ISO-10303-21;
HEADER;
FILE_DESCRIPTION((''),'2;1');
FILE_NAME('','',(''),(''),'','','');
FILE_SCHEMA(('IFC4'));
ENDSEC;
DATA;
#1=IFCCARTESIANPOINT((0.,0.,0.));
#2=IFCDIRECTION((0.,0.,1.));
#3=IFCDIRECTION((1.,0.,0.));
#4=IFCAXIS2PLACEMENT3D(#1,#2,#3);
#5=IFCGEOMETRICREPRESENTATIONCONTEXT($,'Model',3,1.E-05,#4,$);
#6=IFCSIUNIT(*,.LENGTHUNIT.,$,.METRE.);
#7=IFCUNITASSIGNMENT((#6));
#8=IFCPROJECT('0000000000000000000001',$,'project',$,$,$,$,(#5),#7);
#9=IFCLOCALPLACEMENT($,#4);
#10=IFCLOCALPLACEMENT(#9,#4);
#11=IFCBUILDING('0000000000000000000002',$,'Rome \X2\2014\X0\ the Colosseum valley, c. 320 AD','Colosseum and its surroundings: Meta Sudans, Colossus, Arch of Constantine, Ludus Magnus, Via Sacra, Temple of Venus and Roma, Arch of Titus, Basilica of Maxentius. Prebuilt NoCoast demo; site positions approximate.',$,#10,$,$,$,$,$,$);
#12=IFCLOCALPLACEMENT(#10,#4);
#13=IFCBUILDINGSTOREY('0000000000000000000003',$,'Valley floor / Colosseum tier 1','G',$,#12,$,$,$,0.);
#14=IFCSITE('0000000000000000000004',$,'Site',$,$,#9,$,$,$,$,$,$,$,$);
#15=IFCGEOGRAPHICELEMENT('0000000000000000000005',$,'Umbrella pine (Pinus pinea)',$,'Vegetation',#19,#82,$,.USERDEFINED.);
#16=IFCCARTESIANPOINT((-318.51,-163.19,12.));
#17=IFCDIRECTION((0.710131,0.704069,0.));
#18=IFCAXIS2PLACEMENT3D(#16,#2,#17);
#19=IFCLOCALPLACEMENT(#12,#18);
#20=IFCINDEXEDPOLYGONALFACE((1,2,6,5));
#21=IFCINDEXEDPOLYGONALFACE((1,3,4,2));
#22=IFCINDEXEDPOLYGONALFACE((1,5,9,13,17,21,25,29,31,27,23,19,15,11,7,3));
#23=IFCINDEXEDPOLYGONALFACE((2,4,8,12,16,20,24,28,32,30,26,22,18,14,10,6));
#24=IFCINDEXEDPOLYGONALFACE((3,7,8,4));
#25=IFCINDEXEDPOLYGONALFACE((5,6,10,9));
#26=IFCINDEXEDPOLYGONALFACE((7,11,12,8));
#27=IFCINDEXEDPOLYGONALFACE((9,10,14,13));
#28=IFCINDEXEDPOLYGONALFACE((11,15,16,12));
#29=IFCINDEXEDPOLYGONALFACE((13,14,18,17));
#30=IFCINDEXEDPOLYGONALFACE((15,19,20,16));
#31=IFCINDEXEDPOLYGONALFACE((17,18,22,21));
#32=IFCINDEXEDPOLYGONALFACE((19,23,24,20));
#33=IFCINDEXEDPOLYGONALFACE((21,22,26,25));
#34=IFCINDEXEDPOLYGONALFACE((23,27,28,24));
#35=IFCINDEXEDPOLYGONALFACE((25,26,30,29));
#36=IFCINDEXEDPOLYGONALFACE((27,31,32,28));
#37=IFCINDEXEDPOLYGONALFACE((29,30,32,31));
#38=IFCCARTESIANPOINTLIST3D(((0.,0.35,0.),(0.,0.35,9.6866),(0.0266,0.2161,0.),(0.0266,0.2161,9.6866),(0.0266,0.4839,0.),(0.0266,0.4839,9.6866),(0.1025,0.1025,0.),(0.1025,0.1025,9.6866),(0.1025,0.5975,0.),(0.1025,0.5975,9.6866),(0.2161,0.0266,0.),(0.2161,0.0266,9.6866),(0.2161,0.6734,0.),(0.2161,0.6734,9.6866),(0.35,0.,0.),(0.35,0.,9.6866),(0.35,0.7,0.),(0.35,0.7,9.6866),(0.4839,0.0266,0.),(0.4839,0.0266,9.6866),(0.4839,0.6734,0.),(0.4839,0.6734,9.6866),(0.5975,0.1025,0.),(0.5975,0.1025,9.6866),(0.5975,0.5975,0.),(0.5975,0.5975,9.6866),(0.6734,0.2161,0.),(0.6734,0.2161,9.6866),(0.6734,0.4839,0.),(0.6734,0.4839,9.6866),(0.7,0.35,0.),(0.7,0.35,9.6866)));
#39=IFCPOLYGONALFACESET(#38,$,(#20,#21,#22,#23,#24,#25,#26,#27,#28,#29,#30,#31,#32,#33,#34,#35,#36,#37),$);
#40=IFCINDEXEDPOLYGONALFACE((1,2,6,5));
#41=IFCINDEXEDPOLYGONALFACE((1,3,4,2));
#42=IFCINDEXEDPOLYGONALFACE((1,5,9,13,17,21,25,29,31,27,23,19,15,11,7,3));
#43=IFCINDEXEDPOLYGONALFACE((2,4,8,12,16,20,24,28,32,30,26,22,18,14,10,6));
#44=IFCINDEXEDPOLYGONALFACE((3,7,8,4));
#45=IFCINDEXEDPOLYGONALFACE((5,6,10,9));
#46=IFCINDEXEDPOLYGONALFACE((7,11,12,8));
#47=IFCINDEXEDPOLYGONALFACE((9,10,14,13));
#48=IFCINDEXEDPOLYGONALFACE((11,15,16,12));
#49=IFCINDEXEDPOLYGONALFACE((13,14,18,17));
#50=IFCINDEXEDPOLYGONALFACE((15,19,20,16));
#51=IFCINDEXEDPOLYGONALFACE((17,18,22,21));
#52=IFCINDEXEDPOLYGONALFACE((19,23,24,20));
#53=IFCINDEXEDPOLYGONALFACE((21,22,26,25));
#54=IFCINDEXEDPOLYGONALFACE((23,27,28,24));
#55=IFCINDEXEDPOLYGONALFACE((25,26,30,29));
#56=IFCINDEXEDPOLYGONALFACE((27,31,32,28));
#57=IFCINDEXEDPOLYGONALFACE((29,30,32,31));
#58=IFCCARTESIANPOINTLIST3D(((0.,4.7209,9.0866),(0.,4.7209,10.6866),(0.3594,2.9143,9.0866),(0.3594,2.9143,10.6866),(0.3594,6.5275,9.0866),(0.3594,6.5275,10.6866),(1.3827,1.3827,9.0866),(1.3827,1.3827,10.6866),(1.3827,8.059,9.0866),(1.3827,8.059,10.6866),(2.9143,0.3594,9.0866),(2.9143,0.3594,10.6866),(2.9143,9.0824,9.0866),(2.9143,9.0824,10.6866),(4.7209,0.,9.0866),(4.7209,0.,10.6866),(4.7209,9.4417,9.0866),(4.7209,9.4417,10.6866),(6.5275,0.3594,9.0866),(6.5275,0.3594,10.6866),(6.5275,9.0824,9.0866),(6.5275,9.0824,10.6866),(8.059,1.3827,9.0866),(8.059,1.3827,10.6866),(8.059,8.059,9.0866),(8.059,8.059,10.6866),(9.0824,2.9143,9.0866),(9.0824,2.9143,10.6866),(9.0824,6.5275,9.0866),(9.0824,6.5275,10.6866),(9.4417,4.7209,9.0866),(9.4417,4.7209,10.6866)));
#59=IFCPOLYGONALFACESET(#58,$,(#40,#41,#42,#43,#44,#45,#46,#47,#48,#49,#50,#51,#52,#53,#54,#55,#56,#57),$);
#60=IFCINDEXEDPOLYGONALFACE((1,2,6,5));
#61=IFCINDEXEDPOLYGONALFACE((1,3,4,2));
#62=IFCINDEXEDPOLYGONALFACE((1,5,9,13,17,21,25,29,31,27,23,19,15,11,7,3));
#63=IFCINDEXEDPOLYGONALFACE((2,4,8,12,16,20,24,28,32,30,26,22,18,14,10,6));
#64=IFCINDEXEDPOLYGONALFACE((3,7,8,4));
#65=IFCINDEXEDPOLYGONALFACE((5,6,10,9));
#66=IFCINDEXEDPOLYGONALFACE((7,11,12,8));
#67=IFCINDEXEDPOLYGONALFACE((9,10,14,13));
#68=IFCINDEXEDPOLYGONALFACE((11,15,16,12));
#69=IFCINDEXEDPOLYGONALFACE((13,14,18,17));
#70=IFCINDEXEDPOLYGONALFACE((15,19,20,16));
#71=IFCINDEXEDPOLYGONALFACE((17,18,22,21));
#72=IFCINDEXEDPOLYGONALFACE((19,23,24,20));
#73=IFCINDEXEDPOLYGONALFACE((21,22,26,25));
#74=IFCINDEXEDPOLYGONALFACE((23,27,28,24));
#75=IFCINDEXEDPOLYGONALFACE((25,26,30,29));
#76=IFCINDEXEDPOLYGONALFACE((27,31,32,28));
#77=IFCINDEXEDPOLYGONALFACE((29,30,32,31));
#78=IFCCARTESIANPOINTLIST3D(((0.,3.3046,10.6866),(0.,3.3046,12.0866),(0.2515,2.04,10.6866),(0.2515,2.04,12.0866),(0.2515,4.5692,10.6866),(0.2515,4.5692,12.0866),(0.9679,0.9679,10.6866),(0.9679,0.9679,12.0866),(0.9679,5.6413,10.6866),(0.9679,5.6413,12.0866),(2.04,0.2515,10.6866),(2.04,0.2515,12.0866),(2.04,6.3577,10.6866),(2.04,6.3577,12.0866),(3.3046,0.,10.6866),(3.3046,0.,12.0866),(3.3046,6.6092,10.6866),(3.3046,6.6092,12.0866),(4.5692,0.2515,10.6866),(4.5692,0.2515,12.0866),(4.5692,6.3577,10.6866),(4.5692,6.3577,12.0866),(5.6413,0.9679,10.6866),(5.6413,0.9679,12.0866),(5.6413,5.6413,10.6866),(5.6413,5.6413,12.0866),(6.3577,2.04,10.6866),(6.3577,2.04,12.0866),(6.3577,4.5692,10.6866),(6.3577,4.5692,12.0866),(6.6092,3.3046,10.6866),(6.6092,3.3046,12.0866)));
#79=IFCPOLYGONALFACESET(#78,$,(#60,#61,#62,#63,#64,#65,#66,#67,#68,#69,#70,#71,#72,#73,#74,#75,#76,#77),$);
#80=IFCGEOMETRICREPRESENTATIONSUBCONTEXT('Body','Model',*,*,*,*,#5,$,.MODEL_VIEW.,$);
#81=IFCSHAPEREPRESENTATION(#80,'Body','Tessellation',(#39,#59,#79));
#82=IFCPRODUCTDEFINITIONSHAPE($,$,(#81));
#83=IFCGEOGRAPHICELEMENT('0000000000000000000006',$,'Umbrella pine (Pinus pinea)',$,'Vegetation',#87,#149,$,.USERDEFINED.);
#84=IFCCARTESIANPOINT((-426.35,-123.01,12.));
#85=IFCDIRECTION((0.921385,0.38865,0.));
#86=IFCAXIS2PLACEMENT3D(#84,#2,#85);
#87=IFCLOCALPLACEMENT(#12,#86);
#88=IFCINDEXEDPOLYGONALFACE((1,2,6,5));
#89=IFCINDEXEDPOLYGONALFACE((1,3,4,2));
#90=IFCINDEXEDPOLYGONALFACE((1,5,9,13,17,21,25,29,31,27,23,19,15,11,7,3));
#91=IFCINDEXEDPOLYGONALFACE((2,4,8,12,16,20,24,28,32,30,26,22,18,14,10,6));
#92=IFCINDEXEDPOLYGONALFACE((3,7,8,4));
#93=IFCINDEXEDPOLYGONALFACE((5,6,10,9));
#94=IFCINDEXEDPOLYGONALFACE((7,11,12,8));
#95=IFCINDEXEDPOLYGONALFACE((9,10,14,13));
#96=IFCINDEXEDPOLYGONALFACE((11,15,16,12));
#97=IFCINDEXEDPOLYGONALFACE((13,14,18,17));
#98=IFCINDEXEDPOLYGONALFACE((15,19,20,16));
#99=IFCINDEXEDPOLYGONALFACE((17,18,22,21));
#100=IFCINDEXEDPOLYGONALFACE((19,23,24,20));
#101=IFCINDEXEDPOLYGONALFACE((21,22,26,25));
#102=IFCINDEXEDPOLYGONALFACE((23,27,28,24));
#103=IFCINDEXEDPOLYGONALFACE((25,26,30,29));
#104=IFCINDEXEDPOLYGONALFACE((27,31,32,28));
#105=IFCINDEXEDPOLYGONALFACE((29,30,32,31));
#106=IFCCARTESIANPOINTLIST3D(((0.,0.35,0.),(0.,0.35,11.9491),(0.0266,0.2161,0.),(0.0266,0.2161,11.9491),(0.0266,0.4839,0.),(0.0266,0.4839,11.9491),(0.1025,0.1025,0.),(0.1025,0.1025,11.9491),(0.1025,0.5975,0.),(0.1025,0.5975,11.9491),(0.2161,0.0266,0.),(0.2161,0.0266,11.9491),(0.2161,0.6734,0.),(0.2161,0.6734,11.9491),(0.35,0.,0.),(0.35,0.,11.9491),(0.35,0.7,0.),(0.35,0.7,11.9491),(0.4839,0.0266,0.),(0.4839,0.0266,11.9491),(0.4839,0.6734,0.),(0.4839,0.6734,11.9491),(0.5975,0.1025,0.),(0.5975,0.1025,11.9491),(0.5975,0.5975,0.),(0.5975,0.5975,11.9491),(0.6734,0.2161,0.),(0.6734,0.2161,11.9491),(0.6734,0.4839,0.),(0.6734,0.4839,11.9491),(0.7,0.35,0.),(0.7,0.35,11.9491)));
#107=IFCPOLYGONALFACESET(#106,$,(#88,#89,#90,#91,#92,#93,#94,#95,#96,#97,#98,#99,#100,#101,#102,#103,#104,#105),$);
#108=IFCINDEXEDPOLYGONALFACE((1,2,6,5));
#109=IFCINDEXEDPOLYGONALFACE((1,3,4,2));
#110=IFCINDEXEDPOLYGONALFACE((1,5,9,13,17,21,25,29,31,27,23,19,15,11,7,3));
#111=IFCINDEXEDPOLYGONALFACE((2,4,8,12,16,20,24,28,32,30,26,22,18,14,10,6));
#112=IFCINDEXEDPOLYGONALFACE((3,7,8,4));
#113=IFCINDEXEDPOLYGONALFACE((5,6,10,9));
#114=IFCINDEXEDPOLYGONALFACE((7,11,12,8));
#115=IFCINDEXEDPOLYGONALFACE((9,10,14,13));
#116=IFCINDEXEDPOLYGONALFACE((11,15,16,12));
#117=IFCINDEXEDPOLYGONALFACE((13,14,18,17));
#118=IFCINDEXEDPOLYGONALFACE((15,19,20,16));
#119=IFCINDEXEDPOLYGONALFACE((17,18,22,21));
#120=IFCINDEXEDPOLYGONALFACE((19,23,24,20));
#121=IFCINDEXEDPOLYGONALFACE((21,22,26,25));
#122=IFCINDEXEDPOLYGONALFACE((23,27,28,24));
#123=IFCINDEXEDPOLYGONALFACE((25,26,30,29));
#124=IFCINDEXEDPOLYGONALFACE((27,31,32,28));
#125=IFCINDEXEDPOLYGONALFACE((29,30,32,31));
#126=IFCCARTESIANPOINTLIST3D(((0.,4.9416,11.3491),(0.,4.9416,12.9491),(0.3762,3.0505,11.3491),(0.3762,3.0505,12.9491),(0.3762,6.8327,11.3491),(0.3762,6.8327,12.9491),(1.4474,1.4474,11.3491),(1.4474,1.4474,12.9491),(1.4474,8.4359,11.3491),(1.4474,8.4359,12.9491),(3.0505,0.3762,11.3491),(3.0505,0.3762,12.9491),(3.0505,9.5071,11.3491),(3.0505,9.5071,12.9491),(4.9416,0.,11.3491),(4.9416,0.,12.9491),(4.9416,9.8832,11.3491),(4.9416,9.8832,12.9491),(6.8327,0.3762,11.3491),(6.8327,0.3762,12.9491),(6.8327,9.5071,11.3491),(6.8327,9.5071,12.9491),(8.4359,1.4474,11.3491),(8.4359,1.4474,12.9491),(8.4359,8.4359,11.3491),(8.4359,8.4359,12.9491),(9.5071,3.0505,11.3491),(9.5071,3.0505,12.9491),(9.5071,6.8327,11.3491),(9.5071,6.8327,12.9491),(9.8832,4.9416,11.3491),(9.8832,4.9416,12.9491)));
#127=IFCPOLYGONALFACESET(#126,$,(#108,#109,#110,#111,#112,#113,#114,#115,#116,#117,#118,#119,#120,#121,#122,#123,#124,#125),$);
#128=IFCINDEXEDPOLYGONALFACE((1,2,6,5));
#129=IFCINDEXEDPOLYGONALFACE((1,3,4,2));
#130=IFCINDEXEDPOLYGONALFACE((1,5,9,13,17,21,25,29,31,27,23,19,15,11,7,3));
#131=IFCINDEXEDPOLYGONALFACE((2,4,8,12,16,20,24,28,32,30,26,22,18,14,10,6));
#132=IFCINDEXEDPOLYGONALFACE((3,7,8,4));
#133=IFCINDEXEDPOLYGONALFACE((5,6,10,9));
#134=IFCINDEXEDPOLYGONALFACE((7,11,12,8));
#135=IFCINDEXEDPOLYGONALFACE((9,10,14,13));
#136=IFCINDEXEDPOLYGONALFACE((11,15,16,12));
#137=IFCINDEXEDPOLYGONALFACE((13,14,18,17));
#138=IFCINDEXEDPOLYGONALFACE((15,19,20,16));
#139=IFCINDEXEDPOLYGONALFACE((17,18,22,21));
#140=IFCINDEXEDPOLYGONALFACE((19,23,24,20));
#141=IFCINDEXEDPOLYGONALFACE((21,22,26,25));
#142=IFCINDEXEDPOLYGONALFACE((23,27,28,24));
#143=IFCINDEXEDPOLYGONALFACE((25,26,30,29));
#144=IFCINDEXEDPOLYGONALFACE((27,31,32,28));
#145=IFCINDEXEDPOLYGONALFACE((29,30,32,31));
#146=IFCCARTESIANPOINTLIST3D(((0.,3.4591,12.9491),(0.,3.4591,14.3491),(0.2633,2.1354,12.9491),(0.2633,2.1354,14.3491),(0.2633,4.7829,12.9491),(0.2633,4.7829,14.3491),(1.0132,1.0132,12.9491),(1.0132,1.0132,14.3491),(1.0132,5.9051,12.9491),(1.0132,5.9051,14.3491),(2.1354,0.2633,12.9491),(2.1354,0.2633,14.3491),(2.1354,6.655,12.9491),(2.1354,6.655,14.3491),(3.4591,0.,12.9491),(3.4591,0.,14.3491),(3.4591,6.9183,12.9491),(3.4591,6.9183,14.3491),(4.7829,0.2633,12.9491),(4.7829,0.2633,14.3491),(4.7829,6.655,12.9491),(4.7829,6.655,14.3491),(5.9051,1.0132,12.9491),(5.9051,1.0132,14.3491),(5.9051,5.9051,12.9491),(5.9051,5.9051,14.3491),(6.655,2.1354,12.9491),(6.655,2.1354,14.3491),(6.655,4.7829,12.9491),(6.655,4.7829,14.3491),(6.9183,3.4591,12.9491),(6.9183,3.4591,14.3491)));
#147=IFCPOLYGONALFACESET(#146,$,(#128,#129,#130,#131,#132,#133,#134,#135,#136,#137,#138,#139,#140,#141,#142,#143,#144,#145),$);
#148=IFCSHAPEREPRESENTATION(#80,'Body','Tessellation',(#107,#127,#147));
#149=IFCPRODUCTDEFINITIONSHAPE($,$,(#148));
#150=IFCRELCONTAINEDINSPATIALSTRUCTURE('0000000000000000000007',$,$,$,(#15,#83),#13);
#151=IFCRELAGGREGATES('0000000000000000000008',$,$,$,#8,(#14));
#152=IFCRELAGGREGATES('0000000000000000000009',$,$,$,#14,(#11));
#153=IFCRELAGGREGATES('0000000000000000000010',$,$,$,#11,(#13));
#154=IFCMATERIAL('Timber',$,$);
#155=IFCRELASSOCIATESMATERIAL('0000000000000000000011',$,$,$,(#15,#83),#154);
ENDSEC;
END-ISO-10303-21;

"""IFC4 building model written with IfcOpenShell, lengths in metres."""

from ifc_helpers import new_model, si_unit, frame, origin_with_axes, place, context, subcontext, project, spatial, polyline, outline, extrude, material, element, save


model = new_model("IFC4")

# Units and contexts
model_context = context("Model", 3, precision=1e-05, world=origin_with_axes())
body_context = subcontext(model_context, "Body", "Model", "MODEL_VIEW")
ifc_project = project(units=[si_unit("LENGTHUNIT", "METRE")], contexts=[model_context])

# Site, building, storey
site_placement = place(None, origin_with_axes())
site = spatial("IfcSite", under=ifc_project, at=site_placement, Name="Site")
building_placement = place(site_placement, origin_with_axes())
building = spatial("IfcBuilding", under=site, at=building_placement, Name="Rome — the Colosseum valley, c. 320 AD", Description="Colosseum and its surroundings: Meta Sudans, Colossus, Arch of Constantine, Ludus Magnus, Via Sacra, Temple of Venus and Roma, Arch of Titus, Basilica of Maxentius. Prebuilt NoCoast demo; site positions approximate.")
storey_placement = place(building_placement, origin_with_axes())
storey = spatial("IfcBuildingStorey", under=building, at=storey_placement, Name="Valley floor / Colosseum tier 1", Description="G", Elevation=0.0)

# Shared definitions
ifc_material_1 = material(Name="Timber")

# Geographic elements
geographic_element_1_placement = place(storey_placement, frame((-318.51, -163.19, 12.0), z_axis=(0.0, 0.0, 1.0), x_axis=(0.710131, 0.704069, 0.0)))
element("IfcGeographicElement", 1, at=geographic_element_1_placement, inside=storey, material=ifc_material_1, Name="Umbrella pine (Pinus pinea)", ObjectType="Vegetation", PredefinedType="USERDEFINED", context=body_context, shape_type="SweptSolid", body=[
    extrude(outline(polyline([(0.7, 0.35), (0.6734, 0.4839), (0.5975, 0.5975), (0.4839, 0.6734), (0.35, 0.7), (0.2161, 0.6734), (0.1025, 0.5975), (0.0266, 0.4839), (0.0, 0.35), (0.0266, 0.2161), (0.1025, 0.1025), (0.2161, 0.0266), (0.35, 0.0), (0.4839, 0.0266), (0.5975, 0.1025), (0.6734, 0.2161), (0.7, 0.35)])), origin_with_axes(), (0.0, 0.0, 1.0), 9.6866),
    extrude(outline(polyline([(9.4417, 4.7209), (9.0824, 6.5275), (8.059, 8.059), (6.5275, 9.0824), (4.7209, 9.4417), (2.9143, 9.0824), (1.3827, 8.059), (0.3594, 6.5275), (0.0, 4.7209), (0.3594, 2.9143), (1.3827, 1.3827), (2.9143, 0.3594), (4.7209, 0.0), (6.5275, 0.3594), (8.059, 1.3827), (9.0824, 2.9143), (9.4417, 4.7209)])), frame((0.0, 0.0, 9.0866), z_axis=(0.0, 0.0, 1.0), x_axis=(1.0, 0.0, 0.0)), (0.0, 0.0, 1.0), 1.6),
    extrude(outline(polyline([(6.6092, 3.3046), (6.3577, 4.5692), (5.6413, 5.6413), (4.5692, 6.3577), (3.3046, 6.6092), (2.04, 6.3577), (0.9679, 5.6413), (0.2515, 4.5692), (0.0, 3.3046), (0.2515, 2.04), (0.9679, 0.9679), (2.04, 0.2515), (3.3046, 0.0), (4.5692, 0.2515), (5.6413, 0.9679), (6.3577, 2.04), (6.6092, 3.3046)])), frame((0.0, 0.0, 10.6866), z_axis=(0.0, 0.0, 1.0), x_axis=(1.0, 0.0, 0.0)), (0.0, 0.0, 1.0), 1.4),
])
geographic_element_2_placement = place(storey_placement, frame((-426.35, -123.01, 12.0), z_axis=(0.0, 0.0, 1.0), x_axis=(0.921385, 0.38865, 0.0)))
element("IfcGeographicElement", 2, at=geographic_element_2_placement, inside=storey, material=ifc_material_1, Name="Umbrella pine (Pinus pinea)", ObjectType="Vegetation", PredefinedType="USERDEFINED", context=body_context, shape_type="SweptSolid", body=[
    extrude(outline(polyline([(0.7, 0.35), (0.6734, 0.4839), (0.5975, 0.5975), (0.4839, 0.6734), (0.35, 0.7), (0.2161, 0.6734), (0.1025, 0.5975), (0.0266, 0.4839), (0.0, 0.35), (0.0266, 0.2161), (0.1025, 0.1025), (0.2161, 0.0266), (0.35, 0.0), (0.4839, 0.0266), (0.5975, 0.1025), (0.6734, 0.2161), (0.7, 0.35)])), origin_with_axes(), (0.0, 0.0, 1.0), 11.9491),
    extrude(outline(polyline([(9.8832, 4.9416), (9.5071, 6.8327), (8.4359, 8.4359), (6.8327, 9.5071), (4.9416, 9.8832), (3.0505, 9.5071), (1.4474, 8.4359), (0.3762, 6.8327), (0.0, 4.9416), (0.3762, 3.0505), (1.4474, 1.4474), (3.0505, 0.3762), (4.9416, 0.0), (6.8327, 0.3762), (8.4359, 1.4474), (9.5071, 3.0505), (9.8832, 4.9416)])), frame((0.0, 0.0, 11.3491), z_axis=(0.0, 0.0, 1.0), x_axis=(1.0, 0.0, 0.0)), (0.0, 0.0, 1.0), 1.6),
    extrude(outline(polyline([(6.9183, 3.4591), (6.655, 4.7829), (5.9051, 5.9051), (4.7829, 6.655), (3.4591, 6.9183), (2.1354, 6.655), (1.0132, 5.9051), (0.2633, 4.7829), (0.0, 3.4591), (0.2633, 2.1354), (1.0132, 1.0132), (2.1354, 0.2633), (3.4591, 0.0), (4.7829, 0.2633), (5.9051, 1.0132), (6.655, 2.1354), (6.9183, 3.4591)])), frame((0.0, 0.0, 12.9491), z_axis=(0.0, 0.0, 1.0), x_axis=(1.0, 0.0, 0.0)), (0.0, 0.0, 1.0), 1.4),
])

save(model, "model.ifc")
